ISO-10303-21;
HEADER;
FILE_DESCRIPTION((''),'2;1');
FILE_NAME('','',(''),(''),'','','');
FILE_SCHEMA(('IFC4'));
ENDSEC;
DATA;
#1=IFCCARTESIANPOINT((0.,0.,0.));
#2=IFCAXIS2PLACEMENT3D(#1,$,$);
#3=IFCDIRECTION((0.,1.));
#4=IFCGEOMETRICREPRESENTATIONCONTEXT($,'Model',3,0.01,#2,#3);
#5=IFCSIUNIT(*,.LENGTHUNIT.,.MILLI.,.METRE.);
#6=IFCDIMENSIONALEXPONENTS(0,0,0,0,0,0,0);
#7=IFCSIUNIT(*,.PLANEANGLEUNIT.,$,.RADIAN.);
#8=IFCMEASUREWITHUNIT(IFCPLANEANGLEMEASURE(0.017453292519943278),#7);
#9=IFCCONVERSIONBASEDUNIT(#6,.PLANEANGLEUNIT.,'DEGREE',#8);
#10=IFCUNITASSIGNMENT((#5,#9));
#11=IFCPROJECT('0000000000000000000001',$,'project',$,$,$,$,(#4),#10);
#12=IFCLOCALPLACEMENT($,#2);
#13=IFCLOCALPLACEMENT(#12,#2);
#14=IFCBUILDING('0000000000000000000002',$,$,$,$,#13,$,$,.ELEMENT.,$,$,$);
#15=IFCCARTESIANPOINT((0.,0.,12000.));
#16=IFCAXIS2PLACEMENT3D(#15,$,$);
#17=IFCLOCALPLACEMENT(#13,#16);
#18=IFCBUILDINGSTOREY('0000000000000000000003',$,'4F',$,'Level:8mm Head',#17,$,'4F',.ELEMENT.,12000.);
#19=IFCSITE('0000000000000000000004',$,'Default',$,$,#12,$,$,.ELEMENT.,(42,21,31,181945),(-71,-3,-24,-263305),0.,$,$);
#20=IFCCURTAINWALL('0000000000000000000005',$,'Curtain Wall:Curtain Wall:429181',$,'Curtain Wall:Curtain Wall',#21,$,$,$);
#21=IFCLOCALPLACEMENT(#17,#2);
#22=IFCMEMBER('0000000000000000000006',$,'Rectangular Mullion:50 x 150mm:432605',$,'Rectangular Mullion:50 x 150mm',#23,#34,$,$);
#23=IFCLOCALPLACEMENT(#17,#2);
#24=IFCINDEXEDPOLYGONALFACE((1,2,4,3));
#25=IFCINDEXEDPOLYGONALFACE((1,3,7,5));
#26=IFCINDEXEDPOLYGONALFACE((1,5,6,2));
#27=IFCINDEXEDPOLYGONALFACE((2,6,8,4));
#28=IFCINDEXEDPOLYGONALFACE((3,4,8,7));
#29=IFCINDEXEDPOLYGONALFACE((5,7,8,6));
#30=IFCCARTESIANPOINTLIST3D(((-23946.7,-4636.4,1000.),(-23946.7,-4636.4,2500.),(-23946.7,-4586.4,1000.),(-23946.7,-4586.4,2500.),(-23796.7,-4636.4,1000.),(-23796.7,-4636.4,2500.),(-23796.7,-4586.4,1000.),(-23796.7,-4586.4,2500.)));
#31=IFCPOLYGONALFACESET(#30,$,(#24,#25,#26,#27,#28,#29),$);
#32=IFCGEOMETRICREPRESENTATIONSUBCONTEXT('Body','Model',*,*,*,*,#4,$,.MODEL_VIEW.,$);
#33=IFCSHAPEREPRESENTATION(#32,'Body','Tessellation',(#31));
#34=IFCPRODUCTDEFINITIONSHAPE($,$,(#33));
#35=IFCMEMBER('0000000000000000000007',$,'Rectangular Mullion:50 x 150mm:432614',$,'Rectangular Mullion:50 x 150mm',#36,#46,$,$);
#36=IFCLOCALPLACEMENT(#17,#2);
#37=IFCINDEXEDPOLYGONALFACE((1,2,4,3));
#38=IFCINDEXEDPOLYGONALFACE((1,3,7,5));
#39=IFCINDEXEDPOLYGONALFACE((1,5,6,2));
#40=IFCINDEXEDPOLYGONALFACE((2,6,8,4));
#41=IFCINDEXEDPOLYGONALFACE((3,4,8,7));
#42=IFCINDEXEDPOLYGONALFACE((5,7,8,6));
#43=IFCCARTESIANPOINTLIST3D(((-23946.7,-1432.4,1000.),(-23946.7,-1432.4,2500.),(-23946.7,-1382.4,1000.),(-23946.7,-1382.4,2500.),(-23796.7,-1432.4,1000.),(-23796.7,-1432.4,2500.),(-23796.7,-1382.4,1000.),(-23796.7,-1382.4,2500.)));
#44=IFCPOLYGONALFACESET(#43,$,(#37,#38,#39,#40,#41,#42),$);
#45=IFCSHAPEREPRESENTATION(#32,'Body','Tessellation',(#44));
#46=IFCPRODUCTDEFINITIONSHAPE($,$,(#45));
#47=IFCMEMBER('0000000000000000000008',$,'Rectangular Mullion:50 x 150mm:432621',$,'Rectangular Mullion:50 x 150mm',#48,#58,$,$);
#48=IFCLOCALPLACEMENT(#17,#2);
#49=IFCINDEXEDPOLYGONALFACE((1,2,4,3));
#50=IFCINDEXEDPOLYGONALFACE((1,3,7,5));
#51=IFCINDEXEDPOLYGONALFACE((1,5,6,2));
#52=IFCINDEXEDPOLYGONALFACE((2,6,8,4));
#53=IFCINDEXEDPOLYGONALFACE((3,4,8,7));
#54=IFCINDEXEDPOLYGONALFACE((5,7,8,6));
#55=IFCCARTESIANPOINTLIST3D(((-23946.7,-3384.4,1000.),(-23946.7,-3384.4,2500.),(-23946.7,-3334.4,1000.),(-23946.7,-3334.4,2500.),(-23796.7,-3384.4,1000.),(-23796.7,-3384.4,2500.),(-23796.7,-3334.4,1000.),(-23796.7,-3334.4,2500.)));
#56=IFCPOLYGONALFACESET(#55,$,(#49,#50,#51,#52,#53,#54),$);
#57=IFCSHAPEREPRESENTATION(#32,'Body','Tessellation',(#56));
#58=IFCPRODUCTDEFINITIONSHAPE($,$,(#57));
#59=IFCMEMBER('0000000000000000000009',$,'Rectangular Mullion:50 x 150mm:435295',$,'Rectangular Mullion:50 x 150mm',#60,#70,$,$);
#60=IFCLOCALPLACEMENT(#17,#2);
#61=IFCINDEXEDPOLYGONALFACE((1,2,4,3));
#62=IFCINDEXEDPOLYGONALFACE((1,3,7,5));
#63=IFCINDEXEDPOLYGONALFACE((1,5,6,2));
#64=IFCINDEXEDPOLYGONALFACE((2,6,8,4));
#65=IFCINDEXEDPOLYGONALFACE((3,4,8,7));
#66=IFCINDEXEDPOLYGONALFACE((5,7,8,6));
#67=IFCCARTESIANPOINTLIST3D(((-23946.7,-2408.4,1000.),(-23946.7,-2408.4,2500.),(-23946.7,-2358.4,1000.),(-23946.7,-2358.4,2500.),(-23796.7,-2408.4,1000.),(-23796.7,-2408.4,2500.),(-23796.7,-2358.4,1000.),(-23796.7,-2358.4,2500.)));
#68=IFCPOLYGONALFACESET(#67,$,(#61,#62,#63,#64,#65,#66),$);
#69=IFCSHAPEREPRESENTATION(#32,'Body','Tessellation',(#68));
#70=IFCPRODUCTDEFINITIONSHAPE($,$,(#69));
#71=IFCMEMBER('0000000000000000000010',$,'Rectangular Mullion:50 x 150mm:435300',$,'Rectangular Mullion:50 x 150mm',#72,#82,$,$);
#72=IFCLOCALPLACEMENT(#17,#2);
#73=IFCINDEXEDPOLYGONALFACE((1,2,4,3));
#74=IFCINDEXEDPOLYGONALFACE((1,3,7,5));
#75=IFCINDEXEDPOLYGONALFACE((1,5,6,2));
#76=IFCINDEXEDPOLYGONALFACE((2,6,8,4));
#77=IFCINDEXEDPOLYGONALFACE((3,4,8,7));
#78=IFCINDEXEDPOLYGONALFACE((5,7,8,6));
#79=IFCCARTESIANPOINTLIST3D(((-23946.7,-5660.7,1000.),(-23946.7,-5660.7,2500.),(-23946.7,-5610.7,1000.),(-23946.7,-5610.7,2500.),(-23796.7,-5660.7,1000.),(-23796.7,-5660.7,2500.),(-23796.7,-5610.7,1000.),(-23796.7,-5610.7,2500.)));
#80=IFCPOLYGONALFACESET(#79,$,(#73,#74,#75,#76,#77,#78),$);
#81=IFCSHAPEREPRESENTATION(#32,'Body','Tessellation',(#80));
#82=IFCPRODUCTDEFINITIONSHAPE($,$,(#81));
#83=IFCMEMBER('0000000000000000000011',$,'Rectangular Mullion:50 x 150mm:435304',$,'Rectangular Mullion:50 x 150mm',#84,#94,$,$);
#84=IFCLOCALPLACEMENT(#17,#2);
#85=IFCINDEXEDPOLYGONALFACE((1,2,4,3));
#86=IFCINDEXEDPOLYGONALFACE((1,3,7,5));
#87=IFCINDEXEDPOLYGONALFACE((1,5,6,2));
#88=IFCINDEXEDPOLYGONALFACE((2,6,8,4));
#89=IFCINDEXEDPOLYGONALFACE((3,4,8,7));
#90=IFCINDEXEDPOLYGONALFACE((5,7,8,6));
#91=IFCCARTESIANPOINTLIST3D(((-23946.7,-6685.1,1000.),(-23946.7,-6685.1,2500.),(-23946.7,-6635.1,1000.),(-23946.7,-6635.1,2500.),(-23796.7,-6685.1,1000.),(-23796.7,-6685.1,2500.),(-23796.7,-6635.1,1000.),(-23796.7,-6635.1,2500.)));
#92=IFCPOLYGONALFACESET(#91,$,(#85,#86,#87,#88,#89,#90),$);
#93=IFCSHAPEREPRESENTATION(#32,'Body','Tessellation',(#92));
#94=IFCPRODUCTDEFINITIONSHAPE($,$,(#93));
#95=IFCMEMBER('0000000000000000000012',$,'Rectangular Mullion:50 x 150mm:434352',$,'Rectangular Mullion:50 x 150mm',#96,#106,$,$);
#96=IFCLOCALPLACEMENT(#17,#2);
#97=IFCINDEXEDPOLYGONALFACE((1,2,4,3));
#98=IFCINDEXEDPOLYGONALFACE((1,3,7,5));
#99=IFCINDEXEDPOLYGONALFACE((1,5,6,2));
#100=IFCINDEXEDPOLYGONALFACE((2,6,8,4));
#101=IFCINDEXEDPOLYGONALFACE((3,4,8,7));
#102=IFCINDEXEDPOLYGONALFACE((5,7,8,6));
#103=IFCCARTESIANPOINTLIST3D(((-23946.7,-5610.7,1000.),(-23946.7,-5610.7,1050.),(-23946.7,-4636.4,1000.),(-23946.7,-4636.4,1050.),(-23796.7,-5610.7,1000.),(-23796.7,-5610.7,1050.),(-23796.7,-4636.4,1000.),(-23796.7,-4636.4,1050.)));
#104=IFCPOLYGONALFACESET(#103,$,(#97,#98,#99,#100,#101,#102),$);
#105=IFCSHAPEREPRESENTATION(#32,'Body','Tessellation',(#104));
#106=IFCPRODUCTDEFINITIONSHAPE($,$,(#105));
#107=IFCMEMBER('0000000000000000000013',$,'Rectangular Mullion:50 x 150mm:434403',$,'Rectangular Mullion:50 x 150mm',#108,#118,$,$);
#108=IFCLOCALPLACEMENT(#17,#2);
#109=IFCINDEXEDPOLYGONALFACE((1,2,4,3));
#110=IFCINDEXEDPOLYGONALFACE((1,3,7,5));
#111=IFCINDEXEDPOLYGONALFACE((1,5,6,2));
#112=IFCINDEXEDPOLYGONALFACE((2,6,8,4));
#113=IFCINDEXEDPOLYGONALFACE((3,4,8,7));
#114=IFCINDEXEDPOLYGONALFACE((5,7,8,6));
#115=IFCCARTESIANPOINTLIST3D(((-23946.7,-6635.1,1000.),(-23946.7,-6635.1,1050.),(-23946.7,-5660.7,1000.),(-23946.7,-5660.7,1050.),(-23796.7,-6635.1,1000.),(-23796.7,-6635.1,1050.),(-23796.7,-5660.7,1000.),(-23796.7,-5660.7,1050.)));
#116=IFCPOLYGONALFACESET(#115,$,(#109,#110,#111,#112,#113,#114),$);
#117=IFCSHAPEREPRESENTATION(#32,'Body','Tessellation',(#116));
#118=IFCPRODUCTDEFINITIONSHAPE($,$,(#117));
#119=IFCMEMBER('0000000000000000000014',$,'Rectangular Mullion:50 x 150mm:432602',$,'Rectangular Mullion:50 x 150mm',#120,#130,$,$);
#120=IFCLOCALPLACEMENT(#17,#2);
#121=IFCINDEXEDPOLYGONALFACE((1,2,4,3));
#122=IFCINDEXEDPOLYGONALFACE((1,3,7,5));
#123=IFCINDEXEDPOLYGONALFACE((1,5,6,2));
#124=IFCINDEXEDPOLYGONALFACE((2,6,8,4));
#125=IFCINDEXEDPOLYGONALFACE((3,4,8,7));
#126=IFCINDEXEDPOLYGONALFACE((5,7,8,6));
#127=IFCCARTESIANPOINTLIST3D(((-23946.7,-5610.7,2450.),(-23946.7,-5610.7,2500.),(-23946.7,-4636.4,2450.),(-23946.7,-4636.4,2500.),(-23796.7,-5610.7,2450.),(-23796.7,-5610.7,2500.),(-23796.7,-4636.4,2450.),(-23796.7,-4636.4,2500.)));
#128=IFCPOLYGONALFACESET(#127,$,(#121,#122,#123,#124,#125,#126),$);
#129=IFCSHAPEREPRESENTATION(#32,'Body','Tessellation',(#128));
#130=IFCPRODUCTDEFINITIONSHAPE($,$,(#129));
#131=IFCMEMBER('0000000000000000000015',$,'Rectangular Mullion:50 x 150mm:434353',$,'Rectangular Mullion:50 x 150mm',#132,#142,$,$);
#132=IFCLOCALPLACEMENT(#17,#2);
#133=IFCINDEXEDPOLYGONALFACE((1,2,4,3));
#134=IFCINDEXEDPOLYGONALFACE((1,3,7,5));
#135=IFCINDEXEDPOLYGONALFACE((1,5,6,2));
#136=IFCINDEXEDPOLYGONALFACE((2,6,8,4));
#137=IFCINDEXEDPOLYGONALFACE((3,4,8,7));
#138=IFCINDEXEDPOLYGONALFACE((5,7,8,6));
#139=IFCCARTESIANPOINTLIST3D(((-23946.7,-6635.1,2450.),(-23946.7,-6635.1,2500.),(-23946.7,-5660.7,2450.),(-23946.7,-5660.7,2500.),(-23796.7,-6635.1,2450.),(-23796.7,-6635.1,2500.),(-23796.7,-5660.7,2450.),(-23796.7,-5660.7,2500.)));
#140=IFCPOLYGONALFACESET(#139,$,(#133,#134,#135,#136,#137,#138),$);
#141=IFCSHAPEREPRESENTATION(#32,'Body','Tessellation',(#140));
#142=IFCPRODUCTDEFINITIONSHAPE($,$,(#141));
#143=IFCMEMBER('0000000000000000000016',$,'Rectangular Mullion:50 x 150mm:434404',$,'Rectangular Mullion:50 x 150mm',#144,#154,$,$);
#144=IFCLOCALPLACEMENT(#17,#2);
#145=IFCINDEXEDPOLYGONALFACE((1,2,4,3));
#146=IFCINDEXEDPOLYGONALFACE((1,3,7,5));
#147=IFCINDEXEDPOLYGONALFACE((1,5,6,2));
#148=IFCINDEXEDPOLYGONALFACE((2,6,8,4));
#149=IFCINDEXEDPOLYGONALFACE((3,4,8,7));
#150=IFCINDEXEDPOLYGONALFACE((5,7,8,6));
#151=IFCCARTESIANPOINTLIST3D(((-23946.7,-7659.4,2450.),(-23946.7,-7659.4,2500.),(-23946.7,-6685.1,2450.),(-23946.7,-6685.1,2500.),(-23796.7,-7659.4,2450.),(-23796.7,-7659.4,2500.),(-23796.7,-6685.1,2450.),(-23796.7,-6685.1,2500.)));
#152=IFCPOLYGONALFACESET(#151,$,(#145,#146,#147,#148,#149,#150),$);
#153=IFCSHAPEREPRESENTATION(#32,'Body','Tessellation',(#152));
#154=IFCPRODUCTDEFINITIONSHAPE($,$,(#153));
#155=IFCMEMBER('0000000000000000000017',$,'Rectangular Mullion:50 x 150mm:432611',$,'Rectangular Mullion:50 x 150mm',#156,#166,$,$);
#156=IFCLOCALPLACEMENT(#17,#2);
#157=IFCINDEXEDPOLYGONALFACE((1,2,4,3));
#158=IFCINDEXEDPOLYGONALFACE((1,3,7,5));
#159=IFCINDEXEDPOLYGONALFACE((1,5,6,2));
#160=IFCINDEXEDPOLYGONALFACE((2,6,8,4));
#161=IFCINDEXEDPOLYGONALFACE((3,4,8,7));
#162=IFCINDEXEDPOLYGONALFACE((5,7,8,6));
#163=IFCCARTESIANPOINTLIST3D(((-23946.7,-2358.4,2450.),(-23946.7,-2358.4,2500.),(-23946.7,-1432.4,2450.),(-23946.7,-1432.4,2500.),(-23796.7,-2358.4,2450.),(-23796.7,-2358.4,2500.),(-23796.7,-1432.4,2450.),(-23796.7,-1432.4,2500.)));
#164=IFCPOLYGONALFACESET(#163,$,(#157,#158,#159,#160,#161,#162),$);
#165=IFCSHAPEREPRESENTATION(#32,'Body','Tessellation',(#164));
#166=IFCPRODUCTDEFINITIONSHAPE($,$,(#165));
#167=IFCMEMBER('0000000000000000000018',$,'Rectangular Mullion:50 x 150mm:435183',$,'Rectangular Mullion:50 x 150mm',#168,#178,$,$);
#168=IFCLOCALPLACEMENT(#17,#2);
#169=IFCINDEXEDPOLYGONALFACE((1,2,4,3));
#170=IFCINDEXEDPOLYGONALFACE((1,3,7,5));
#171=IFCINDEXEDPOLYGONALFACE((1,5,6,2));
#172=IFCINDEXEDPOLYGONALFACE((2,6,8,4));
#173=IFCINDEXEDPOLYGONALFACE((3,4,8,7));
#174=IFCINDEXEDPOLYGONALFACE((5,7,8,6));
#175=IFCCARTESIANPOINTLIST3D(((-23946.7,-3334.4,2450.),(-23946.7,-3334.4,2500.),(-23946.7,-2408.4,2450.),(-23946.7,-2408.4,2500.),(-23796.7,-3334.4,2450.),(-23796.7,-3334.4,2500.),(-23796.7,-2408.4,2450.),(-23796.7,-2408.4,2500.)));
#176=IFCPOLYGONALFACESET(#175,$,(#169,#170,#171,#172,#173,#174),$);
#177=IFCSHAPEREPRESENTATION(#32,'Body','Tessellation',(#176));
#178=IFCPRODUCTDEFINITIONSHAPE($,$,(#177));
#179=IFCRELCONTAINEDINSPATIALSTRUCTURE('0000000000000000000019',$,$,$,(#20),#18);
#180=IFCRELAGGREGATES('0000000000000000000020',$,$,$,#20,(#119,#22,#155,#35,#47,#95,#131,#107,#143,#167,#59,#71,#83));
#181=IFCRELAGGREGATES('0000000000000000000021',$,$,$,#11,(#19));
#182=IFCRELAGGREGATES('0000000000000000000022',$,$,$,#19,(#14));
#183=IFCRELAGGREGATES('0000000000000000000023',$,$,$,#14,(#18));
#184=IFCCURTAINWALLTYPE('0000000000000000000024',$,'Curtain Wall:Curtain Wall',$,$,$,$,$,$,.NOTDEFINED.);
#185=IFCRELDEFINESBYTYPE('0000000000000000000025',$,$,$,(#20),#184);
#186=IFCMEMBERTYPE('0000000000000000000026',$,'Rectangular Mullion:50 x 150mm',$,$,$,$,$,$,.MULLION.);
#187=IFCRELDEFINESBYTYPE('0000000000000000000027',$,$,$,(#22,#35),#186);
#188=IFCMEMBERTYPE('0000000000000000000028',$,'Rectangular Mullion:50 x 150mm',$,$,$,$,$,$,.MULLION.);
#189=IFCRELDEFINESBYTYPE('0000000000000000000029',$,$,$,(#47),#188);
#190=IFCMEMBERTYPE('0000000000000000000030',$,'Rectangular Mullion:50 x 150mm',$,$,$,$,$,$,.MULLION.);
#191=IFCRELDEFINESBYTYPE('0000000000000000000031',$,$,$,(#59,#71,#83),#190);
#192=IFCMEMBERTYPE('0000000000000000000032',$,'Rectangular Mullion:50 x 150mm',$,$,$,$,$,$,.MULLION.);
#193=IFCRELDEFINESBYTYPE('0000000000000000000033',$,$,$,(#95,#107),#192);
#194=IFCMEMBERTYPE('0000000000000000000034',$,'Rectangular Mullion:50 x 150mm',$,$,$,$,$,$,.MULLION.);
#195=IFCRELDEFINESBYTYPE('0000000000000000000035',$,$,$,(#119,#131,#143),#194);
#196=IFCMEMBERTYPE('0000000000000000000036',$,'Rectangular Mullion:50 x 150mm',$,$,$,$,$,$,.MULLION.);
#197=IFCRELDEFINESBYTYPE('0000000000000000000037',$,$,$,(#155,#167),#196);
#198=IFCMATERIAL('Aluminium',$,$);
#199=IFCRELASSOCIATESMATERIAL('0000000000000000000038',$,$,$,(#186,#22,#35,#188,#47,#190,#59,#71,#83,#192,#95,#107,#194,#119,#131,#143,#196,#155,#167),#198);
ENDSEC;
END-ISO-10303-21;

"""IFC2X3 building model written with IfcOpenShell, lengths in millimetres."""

from ifc_helpers import new_model, entity, si_unit, converted_unit, direction, frame, origin, origin_2d_with_axis, place, context, subcontext, project, spatial, rectangle, extrude, source, transform, mapped, material, type_object, type_shapes, element, aggregate, save


model = new_model("IFC2X3")

# Units and contexts
model_context = context("Model", 3, precision=0.01, world=origin(), true_north=direction((0.0, 1.0)))
body_context = subcontext(model_context, "Body", "Model", "MODEL_VIEW")
ifc_project = project(units=[si_unit("LENGTHUNIT", "METRE", prefix="MILLI"), converted_unit("PLANEANGLEUNIT", "DEGREE", entity("IfcPlaneAngleMeasure", 0.017453292519943278), si_unit("PLANEANGLEUNIT", "RADIAN"), dimensions=[0, 0, 0, 0, 0, 0, 0])], contexts=[model_context])

# Site, building, storey
site_placement = place(None, origin())
site = spatial("IfcSite", under=ifc_project, at=site_placement, Name="Default", CompositionType="ELEMENT", RefLatitude=(42, 21, 31, 181945), RefLongitude=(-71, -3, -24, -263305), RefElevation=0.0)
building_placement = place(site_placement, origin())
building = spatial("IfcBuilding", under=site, at=building_placement, CompositionType="ELEMENT")
storey_placement = place(building_placement, frame((0.0, 0.0, 12000.0)))
storey = spatial("IfcBuildingStorey", under=building, at=storey_placement, Name="4F", ObjectType="Level:8mm Head", LongName="4F", CompositionType="ELEMENT", Elevation=12000.0)

# Curtain wall, members
curtain_wall_type = type_object("IfcCurtainWallType", Name="Curtain Wall:Curtain Wall", PredefinedType="NOTDEFINED")
curtain_wall_placement = place(storey_placement, frame((0.0, 0.0, -12000.0)))
curtain_wall = element("IfcCurtainWall", 1, at=curtain_wall_placement, inside=storey, type_object=curtain_wall_type, Name="Curtain Wall:Curtain Wall:429181", ObjectType="Curtain Wall:Curtain Wall")
ifc_material_1 = material(Name="Aluminium")
member_type_1 = type_object("IfcMemberType", Name="Rectangular Mullion:50 x 150mm", PredefinedType="MULLION", material=ifc_material_1)
shared_shape_1 = source(origin(), body_context, "Body", "SweptSolid", [
    extrude(rectangle(XDim=50.0, YDim=150.0, at=origin_2d_with_axis()), frame((-25.0, 0.0, -1500.0), z_axis=(0.0, 0.0, 1.0), x_axis=(-1.0, 0.0, 0.0)), (0.0, 0.0, 1.0), 1500.0),
])
type_shapes(member_type_1, [shared_shape_1])
member_1_placement = place(curtain_wall_placement, frame((-23871.7, -4586.4, 13000.0), z_axis=(0.0, 0.0, -1.0), x_axis=(0.0, 1.0, 0.0)))
member_1 = element("IfcMember", 2, at=member_1_placement, type_object=member_type_1, material=ifc_material_1, Name="Rectangular Mullion:50 x 150mm:432605", ObjectType="Rectangular Mullion:50 x 150mm", context=body_context, shape_type="MappedRepresentation", body=[
    mapped(shared_shape_1, transform((0.0, 0.0, 0.0), scale=1.0)),
])
member_2_placement = place(curtain_wall_placement, frame((-23871.7, -1382.4, 13000.0), z_axis=(0.0, 0.0, -1.0), x_axis=(0.0, 1.0, 0.0)))
member_2 = element("IfcMember", 3, at=member_2_placement, type_object=member_type_1, material=ifc_material_1, Name="Rectangular Mullion:50 x 150mm:432614", ObjectType="Rectangular Mullion:50 x 150mm", context=body_context, shape_type="MappedRepresentation", body=[
    mapped(shared_shape_1, transform((0.0, 0.0, 0.0), scale=1.0)),
])
member_type_2 = type_object("IfcMemberType", Name="Rectangular Mullion:50 x 150mm", PredefinedType="MULLION", material=ifc_material_1)
shared_shape_2 = source(origin(), body_context, "Body", "SweptSolid", [
    extrude(rectangle(XDim=50.0, YDim=150.0, at=origin_2d_with_axis()), frame((-25.0, 0.0, -1500.0), z_axis=(0.0, 0.0, 1.0), x_axis=(-1.0, 0.0, 0.0)), (0.0, 0.0, 1.0), 1500.0),
])
type_shapes(member_type_2, [shared_shape_2])
member_3_placement = place(curtain_wall_placement, frame((-23871.7, -3384.4, 14500.0), z_axis=(0.0, 0.0, 1.0), x_axis=(0.0, -1.0, 0.0)))
member_3 = element("IfcMember", 4, at=member_3_placement, type_object=member_type_2, material=ifc_material_1, Name="Rectangular Mullion:50 x 150mm:432621", ObjectType="Rectangular Mullion:50 x 150mm", context=body_context, shape_type="MappedRepresentation", body=[
    mapped(shared_shape_2, transform((0.0, 0.0, 0.0), scale=1.0)),
])
member_type_3 = type_object("IfcMemberType", Name="Rectangular Mullion:50 x 150mm", PredefinedType="MULLION", material=ifc_material_1)
shared_shape_3 = source(origin(), body_context, "Body", "SweptSolid", [
    extrude(rectangle(XDim=50.0, YDim=150.0, at=origin_2d_with_axis()), frame((0.0, 0.0, -1500.0), z_axis=(0.0, 0.0, 1.0), x_axis=(-1.0, 0.0, 0.0)), (0.0, 0.0, 1.0), 1500.0),
])
type_shapes(member_type_3, [shared_shape_3])
member_4_placement = place(curtain_wall_placement, frame((-23871.7, -2383.4, 13000.0), z_axis=(0.0, 0.0, -1.0), x_axis=(0.0, 1.0, 0.0)))
member_4 = element("IfcMember", 5, at=member_4_placement, type_object=member_type_3, material=ifc_material_1, Name="Rectangular Mullion:50 x 150mm:435295", ObjectType="Rectangular Mullion:50 x 150mm", context=body_context, shape_type="MappedRepresentation", body=[
    mapped(shared_shape_3, transform((0.0, 0.0, 0.0), scale=1.0)),
])
member_5_placement = place(curtain_wall_placement, frame((-23871.7, -5635.7, 13000.0), z_axis=(0.0, 0.0, -1.0), x_axis=(0.0, 1.0, 0.0)))
member_5 = element("IfcMember", 6, at=member_5_placement, type_object=member_type_3, material=ifc_material_1, Name="Rectangular Mullion:50 x 150mm:435300", ObjectType="Rectangular Mullion:50 x 150mm", context=body_context, shape_type="MappedRepresentation", body=[
    mapped(shared_shape_3, transform((0.0, 0.0, 0.0), scale=1.0)),
])
member_6_placement = place(curtain_wall_placement, frame((-23871.7, -6660.1, 13000.0), z_axis=(0.0, 0.0, -1.0), x_axis=(0.0, 1.0, 0.0)))
member_6 = element("IfcMember", 7, at=member_6_placement, type_object=member_type_3, material=ifc_material_1, Name="Rectangular Mullion:50 x 150mm:435304", ObjectType="Rectangular Mullion:50 x 150mm", context=body_context, shape_type="MappedRepresentation", body=[
    mapped(shared_shape_3, transform((0.0, 0.0, 0.0), scale=1.0)),
])
member_type_4 = type_object("IfcMemberType", Name="Rectangular Mullion:50 x 150mm", PredefinedType="MULLION", material=ifc_material_1)
shared_shape_4 = source(origin(), body_context, "Body", "SweptSolid", [
    extrude(rectangle(XDim=50.0, YDim=150.0, at=origin_2d_with_axis()), frame((-25.0, 0.0, -974.3), z_axis=(0.0, 0.0, 1.0), x_axis=(-1.0, 0.0, 0.0)), (0.0, 0.0, 1.0), 974.3),
])
type_shapes(member_type_4, [shared_shape_4])
member_7_placement = place(curtain_wall_placement, frame((-23871.7, -5610.7, 13000.0), z_axis=(0.0, -1.0, 0.0), x_axis=(0.0, 0.0, -1.0)))
member_7 = element("IfcMember", 8, at=member_7_placement, type_object=member_type_4, material=ifc_material_1, Name="Rectangular Mullion:50 x 150mm:434352", ObjectType="Rectangular Mullion:50 x 150mm", context=body_context, shape_type="MappedRepresentation", body=[
    mapped(shared_shape_4, transform((0.0, 0.0, 0.0), scale=1.0)),
])
member_8_placement = place(curtain_wall_placement, frame((-23871.7, -6635.1, 13000.0), z_axis=(0.0, -1.0, 0.0), x_axis=(0.0, 0.0, -1.0)))
member_8 = element("IfcMember", 9, at=member_8_placement, type_object=member_type_4, material=ifc_material_1, Name="Rectangular Mullion:50 x 150mm:434403", ObjectType="Rectangular Mullion:50 x 150mm", context=body_context, shape_type="MappedRepresentation", body=[
    mapped(shared_shape_4, transform((0.0, 0.0, 0.0), scale=1.0)),
])
member_type_5 = type_object("IfcMemberType", Name="Rectangular Mullion:50 x 150mm", PredefinedType="MULLION", material=ifc_material_1)
shared_shape_5 = source(origin(), body_context, "Body", "SweptSolid", [
    extrude(rectangle(XDim=50.0, YDim=150.0, at=origin_2d_with_axis()), frame((-25.0, 0.0, -974.3), z_axis=(0.0, 0.0, 1.0), x_axis=(-1.0, 0.0, 0.0)), (0.0, 0.0, 1.0), 974.3),
])
type_shapes(member_type_5, [shared_shape_5])
member_9_placement = place(curtain_wall_placement, frame((-23871.7, -4636.4, 14500.0), z_axis=(0.0, 1.0, 0.0), x_axis=(0.0, 0.0, 1.0)))
member_9 = element("IfcMember", 10, at=member_9_placement, type_object=member_type_5, material=ifc_material_1, Name="Rectangular Mullion:50 x 150mm:432602", ObjectType="Rectangular Mullion:50 x 150mm", context=body_context, shape_type="MappedRepresentation", body=[
    mapped(shared_shape_5, transform((0.0, 0.0, 0.0), scale=1.0)),
])
member_10_placement = place(curtain_wall_placement, frame((-23871.7, -5660.7, 14500.0), z_axis=(0.0, 1.0, 0.0), x_axis=(0.0, 0.0, 1.0)))
member_10 = element("IfcMember", 11, at=member_10_placement, type_object=member_type_5, material=ifc_material_1, Name="Rectangular Mullion:50 x 150mm:434353", ObjectType="Rectangular Mullion:50 x 150mm", context=body_context, shape_type="MappedRepresentation", body=[
    mapped(shared_shape_5, transform((0.0, 0.0, 0.0), scale=1.0)),
])
member_11_placement = place(curtain_wall_placement, frame((-23871.7, -6685.1, 14500.0), z_axis=(0.0, 1.0, 0.0), x_axis=(0.0, 0.0, 1.0)))
member_11 = element("IfcMember", 12, at=member_11_placement, type_object=member_type_5, material=ifc_material_1, Name="Rectangular Mullion:50 x 150mm:434404", ObjectType="Rectangular Mullion:50 x 150mm", context=body_context, shape_type="MappedRepresentation", body=[
    mapped(shared_shape_5, transform((0.0, 0.0, 0.0), scale=1.0)),
])
member_type_6 = type_object("IfcMemberType", Name="Rectangular Mullion:50 x 150mm", PredefinedType="MULLION", material=ifc_material_1)
shared_shape_6 = source(origin(), body_context, "Body", "SweptSolid", [
    extrude(rectangle(XDim=50.0, YDim=150.0, at=origin_2d_with_axis()), frame((-25.0, 0.0, -926.0), z_axis=(0.0, 0.0, 1.0), x_axis=(-1.0, 0.0, 0.0)), (0.0, 0.0, 1.0), 926.0),
])
type_shapes(member_type_6, [shared_shape_6])
member_12_placement = place(curtain_wall_placement, frame((-23871.7, -1432.4, 14500.0), z_axis=(0.0, 1.0, 0.0), x_axis=(0.0, 0.0, 1.0)))
member_12 = element("IfcMember", 13, at=member_12_placement, type_object=member_type_6, material=ifc_material_1, Name="Rectangular Mullion:50 x 150mm:432611", ObjectType="Rectangular Mullion:50 x 150mm", context=body_context, shape_type="MappedRepresentation", body=[
    mapped(shared_shape_6, transform((0.0, 0.0, 0.0), scale=1.0)),
])
member_13_placement = place(curtain_wall_placement, frame((-23871.7, -2408.4, 14500.0), z_axis=(0.0, 1.0, 0.0), x_axis=(0.0, 0.0, 1.0)))
member_13 = element("IfcMember", 14, at=member_13_placement, type_object=member_type_6, material=ifc_material_1, Name="Rectangular Mullion:50 x 150mm:435183", ObjectType="Rectangular Mullion:50 x 150mm", context=body_context, shape_type="MappedRepresentation", body=[
    mapped(shared_shape_6, transform((0.0, 0.0, 0.0), scale=1.0)),
])
aggregate(curtain_wall, [member_9, member_1, member_12, member_2, member_3, member_7, member_10, member_8, member_11, member_13, member_4, member_5, member_6])

save(model, "model.ifc")
